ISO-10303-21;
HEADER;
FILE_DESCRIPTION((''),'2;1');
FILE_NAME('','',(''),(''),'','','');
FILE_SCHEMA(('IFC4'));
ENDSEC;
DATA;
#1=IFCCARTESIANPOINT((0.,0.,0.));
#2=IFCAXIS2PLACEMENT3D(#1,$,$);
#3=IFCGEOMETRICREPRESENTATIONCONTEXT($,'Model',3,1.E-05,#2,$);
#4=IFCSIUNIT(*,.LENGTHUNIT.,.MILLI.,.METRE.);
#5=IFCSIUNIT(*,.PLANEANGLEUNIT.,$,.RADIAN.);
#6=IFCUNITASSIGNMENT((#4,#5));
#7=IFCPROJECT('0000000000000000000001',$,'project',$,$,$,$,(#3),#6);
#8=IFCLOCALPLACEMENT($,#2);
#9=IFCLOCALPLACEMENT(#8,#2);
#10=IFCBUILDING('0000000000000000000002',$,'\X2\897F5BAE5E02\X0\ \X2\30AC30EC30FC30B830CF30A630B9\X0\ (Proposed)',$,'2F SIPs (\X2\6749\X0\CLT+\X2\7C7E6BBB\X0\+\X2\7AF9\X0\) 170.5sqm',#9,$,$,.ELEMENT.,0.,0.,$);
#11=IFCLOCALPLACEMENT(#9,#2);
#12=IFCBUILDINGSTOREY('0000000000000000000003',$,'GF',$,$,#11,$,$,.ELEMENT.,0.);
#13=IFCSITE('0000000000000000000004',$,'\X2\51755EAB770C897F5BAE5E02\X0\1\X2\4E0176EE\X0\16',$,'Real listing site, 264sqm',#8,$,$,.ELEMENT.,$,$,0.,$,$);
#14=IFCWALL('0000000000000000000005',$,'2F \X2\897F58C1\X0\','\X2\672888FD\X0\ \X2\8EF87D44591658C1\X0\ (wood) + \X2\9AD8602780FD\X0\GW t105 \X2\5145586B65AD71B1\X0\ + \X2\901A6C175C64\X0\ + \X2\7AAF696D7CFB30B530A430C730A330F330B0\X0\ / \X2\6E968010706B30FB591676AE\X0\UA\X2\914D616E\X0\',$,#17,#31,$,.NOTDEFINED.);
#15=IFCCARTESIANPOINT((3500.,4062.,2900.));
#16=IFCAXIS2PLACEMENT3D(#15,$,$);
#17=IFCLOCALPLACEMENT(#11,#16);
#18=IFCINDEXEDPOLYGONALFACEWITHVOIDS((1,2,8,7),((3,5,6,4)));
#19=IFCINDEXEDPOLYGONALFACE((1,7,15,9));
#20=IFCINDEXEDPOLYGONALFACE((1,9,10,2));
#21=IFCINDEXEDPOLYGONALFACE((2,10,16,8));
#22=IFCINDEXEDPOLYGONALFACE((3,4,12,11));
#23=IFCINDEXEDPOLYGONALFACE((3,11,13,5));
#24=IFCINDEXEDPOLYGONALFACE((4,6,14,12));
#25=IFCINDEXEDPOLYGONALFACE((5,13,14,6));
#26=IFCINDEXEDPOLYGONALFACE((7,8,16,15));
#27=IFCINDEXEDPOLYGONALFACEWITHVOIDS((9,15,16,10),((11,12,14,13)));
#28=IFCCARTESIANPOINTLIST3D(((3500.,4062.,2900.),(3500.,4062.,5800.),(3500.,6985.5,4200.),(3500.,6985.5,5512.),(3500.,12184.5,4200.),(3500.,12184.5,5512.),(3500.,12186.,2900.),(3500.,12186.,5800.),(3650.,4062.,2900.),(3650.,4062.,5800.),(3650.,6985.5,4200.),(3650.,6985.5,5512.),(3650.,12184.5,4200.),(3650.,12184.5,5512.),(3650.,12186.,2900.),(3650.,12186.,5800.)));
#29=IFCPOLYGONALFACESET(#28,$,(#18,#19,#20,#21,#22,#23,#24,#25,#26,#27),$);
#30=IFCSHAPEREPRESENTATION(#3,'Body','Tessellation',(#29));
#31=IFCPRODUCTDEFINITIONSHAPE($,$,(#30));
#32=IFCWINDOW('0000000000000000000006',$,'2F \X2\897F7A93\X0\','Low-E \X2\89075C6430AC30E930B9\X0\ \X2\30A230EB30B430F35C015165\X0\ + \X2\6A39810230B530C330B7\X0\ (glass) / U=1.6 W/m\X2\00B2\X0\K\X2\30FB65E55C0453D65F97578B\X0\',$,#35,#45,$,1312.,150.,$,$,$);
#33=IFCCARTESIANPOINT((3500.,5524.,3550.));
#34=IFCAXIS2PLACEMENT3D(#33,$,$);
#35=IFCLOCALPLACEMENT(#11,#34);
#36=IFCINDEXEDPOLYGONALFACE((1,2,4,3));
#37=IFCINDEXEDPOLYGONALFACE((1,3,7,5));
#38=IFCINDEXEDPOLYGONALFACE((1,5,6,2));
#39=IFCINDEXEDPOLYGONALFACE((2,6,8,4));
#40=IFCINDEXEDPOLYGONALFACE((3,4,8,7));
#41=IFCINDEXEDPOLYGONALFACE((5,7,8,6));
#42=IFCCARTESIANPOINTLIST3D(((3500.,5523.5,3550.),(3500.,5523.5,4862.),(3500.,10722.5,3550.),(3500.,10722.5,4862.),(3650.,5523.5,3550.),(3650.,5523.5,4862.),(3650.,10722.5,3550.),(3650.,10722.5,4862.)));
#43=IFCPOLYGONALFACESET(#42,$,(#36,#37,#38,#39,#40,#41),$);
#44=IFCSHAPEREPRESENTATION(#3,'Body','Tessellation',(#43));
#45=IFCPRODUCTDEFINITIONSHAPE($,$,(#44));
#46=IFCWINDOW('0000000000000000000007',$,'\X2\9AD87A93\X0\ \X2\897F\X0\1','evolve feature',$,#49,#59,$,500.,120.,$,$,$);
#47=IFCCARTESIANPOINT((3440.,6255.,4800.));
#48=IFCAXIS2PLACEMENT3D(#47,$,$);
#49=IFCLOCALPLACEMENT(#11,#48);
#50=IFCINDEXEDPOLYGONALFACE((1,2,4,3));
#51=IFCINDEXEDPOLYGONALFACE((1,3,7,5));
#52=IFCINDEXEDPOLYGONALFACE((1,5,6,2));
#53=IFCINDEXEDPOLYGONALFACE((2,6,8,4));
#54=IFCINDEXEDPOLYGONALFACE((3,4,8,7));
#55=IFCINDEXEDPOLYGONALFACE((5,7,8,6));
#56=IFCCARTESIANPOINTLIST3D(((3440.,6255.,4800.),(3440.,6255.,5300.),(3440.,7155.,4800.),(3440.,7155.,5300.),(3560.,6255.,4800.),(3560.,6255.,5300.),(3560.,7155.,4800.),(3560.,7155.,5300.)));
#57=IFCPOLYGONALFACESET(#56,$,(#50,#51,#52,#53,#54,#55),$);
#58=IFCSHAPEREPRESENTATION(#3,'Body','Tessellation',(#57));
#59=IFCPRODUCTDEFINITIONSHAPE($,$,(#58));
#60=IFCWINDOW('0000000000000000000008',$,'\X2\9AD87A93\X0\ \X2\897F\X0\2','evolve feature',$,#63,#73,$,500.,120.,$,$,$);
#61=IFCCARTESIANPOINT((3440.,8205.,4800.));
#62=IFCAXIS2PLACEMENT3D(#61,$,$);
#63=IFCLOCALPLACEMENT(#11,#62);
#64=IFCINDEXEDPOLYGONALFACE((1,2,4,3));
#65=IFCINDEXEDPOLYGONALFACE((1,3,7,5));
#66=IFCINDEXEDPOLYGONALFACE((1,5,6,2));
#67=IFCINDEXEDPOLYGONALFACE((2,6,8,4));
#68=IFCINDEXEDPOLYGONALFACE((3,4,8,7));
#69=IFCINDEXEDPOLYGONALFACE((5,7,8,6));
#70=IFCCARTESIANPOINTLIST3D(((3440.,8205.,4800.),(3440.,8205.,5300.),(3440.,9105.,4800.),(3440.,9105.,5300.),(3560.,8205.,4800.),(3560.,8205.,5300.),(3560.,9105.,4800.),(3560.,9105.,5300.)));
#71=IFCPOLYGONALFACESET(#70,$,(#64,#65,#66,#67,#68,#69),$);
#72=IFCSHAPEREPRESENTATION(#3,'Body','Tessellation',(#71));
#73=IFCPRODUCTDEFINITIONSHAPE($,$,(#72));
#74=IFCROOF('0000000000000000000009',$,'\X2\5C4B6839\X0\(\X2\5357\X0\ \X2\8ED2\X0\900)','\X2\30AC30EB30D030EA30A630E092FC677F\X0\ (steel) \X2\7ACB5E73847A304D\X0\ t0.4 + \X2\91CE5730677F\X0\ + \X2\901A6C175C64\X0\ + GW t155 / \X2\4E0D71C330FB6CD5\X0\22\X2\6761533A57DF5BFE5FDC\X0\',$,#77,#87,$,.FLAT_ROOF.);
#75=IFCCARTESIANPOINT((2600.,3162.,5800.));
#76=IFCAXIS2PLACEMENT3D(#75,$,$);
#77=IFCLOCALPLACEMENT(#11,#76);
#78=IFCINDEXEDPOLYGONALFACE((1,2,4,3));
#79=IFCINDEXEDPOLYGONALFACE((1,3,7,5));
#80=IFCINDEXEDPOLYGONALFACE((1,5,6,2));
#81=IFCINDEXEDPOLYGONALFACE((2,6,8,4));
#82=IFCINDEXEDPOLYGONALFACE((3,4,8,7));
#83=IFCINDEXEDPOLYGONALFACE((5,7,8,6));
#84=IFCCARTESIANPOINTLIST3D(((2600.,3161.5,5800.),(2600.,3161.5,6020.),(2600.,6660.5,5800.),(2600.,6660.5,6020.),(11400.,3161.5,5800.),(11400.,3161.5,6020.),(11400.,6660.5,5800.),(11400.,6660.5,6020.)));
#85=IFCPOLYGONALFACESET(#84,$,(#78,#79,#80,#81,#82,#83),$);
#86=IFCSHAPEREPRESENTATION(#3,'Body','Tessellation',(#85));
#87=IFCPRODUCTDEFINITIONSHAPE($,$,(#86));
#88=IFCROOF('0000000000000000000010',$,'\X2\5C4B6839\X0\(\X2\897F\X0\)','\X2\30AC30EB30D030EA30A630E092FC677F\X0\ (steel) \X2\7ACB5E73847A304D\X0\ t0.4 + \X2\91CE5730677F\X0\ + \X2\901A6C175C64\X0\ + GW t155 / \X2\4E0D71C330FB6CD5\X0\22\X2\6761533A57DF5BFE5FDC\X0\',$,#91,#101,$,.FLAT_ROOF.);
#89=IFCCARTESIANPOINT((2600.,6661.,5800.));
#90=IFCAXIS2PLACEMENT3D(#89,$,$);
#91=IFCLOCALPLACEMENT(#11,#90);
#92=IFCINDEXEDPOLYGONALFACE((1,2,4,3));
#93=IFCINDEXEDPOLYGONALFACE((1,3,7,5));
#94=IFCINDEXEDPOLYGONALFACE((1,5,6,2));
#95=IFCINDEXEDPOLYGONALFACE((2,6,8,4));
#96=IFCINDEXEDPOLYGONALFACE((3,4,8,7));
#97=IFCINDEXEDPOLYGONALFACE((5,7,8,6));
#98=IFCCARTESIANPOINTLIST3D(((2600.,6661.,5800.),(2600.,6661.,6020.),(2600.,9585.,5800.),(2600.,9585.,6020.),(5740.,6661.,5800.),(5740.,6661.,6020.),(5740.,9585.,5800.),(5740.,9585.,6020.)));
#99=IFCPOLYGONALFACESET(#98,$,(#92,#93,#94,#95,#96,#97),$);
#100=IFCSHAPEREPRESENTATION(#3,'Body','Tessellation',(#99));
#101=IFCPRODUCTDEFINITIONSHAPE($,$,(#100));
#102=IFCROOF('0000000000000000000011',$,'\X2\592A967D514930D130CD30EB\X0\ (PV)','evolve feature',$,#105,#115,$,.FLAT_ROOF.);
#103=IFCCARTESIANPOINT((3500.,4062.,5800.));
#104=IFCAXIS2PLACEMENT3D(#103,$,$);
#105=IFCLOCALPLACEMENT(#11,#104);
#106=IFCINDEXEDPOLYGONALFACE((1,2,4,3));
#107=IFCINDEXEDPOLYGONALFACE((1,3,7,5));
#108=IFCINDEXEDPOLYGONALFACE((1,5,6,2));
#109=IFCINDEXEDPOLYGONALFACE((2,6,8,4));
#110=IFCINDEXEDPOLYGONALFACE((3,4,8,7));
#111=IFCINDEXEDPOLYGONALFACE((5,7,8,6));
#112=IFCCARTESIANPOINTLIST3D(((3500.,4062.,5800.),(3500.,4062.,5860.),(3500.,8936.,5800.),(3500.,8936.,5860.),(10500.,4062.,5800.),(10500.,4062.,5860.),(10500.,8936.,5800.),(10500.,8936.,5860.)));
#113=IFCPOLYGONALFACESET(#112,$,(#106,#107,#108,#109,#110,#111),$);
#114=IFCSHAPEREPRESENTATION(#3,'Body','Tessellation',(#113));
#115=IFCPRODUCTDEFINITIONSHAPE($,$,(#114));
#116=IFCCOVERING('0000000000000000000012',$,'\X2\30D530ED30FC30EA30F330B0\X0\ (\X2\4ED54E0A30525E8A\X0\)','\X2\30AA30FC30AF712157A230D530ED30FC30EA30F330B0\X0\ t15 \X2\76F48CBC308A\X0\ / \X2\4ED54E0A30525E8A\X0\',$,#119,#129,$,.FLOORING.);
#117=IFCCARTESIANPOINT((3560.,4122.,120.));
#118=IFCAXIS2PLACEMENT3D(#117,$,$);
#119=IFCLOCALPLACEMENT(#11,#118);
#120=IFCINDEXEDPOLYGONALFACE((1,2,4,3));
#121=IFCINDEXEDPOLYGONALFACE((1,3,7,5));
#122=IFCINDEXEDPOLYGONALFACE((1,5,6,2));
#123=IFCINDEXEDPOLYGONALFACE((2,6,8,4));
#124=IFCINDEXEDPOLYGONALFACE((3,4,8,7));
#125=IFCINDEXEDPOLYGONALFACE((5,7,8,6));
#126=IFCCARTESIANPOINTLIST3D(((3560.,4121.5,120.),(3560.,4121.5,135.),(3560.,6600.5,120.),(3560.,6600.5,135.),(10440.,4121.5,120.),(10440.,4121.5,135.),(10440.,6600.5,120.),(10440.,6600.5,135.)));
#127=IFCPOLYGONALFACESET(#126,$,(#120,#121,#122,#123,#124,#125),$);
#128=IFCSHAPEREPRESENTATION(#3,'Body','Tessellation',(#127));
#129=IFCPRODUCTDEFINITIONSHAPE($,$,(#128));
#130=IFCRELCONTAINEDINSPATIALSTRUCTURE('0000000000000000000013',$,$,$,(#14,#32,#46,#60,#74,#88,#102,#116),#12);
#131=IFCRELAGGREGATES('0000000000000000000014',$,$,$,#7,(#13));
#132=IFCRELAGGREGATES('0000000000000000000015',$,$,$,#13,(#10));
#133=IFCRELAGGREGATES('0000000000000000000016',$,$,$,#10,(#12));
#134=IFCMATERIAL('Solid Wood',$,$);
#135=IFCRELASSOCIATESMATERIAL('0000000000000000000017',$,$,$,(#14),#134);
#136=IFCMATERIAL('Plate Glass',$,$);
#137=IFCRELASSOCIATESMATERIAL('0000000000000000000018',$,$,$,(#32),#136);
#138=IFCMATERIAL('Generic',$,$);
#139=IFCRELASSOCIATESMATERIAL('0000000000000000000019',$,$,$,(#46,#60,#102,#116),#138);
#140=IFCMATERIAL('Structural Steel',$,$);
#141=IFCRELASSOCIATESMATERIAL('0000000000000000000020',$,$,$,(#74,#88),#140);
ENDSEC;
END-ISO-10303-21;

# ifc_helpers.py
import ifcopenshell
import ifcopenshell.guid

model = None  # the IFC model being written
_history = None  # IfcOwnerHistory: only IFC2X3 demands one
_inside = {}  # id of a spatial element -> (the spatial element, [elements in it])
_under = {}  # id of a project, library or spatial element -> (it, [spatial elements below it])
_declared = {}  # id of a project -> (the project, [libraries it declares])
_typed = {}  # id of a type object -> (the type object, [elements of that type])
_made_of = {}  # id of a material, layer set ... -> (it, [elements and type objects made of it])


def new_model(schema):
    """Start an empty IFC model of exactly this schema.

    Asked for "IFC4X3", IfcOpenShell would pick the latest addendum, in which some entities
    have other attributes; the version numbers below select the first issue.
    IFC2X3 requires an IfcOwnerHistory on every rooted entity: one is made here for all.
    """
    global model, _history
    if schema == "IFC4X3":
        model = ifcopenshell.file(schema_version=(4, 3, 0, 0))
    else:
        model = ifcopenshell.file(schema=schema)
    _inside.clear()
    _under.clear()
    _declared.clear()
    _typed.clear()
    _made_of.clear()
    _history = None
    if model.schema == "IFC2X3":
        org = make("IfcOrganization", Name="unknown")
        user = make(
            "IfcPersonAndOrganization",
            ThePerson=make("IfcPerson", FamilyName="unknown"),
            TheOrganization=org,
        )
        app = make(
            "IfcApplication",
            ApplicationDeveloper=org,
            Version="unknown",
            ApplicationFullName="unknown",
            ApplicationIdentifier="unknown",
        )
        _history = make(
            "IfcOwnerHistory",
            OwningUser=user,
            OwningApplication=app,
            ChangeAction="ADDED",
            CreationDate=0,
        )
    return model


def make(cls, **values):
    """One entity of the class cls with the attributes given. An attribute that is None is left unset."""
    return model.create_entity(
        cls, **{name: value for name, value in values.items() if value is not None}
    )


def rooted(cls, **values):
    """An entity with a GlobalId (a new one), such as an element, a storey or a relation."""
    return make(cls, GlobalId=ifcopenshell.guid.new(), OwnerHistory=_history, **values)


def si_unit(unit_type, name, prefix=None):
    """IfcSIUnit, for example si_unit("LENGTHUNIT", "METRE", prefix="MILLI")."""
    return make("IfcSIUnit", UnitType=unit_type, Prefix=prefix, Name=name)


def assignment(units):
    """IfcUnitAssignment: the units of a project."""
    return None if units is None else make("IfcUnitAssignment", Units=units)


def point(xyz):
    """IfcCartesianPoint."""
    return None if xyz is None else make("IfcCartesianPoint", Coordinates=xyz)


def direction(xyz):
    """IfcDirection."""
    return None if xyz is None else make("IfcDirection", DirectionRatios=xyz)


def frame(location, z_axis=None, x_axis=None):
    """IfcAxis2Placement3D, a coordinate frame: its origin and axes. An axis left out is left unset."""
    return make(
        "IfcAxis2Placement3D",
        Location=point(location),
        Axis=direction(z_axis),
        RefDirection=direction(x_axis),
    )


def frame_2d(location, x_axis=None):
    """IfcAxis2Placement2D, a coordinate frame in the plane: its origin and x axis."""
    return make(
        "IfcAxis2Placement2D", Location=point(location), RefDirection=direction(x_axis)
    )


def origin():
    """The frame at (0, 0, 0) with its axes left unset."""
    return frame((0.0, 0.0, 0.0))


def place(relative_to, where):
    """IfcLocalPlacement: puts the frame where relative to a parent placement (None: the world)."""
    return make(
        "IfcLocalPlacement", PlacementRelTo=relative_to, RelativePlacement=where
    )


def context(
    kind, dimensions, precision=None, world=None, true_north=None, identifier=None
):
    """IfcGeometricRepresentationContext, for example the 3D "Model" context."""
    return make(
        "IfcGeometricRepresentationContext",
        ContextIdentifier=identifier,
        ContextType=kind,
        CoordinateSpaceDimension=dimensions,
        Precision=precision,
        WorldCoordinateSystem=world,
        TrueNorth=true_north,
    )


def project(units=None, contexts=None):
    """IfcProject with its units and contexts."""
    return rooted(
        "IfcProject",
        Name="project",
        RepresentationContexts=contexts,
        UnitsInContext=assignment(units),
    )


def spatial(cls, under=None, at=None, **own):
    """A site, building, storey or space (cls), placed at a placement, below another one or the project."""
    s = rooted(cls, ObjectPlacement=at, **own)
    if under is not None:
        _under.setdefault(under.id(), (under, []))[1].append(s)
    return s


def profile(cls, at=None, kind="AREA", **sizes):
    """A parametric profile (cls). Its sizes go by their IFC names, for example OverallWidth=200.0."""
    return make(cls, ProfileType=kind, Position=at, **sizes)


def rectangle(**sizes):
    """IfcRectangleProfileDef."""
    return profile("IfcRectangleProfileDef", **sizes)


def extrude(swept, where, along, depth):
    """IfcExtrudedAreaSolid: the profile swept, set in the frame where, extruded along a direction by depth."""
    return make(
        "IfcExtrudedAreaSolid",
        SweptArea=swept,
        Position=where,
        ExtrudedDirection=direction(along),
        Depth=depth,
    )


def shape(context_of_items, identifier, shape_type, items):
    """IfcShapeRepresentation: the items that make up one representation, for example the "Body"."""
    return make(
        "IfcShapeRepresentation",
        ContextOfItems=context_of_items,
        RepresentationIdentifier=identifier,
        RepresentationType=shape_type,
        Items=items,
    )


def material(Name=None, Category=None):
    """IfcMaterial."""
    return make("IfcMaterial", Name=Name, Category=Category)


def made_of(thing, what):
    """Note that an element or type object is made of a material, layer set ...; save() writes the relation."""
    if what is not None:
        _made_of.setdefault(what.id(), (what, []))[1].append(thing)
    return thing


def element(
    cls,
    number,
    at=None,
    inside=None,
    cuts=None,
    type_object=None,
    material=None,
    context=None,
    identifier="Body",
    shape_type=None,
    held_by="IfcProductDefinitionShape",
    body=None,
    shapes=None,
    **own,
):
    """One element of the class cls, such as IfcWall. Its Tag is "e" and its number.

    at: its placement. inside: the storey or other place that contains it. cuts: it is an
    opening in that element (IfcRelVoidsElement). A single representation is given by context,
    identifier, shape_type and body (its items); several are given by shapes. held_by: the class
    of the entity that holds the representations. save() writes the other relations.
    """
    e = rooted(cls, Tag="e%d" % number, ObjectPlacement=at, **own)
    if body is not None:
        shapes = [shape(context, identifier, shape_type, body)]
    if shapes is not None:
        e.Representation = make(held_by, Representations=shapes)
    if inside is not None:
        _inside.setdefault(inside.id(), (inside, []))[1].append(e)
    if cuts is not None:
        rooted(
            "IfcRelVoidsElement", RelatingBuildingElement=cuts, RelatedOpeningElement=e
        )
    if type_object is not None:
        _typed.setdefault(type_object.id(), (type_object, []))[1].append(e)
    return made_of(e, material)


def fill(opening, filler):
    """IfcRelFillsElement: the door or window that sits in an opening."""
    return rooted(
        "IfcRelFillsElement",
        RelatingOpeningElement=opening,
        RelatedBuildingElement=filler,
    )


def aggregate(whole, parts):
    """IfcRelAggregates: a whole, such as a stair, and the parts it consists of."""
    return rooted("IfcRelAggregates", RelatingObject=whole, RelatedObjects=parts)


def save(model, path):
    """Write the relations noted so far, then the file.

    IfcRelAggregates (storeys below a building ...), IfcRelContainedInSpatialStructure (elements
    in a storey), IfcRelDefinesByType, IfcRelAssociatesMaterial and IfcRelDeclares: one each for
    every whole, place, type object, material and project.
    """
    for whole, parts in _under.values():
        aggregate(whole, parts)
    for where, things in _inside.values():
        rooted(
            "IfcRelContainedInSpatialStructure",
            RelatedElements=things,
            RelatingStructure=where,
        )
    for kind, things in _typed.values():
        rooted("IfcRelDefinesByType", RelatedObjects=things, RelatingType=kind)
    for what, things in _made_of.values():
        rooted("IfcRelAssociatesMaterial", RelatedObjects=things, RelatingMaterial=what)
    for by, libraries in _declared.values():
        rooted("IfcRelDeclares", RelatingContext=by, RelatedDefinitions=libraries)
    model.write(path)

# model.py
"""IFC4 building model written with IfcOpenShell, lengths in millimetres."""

from ifc_helpers import new_model, si_unit, frame, frame_2d, origin, place, context, project, spatial, rectangle, extrude, material, element, fill, save


model = new_model("IFC4")

# Units and contexts
model_context = context("Model", 3, precision=1e-05, world=origin())
ifc_project = project(units=[si_unit("LENGTHUNIT", "METRE", prefix="MILLI"), si_unit("PLANEANGLEUNIT", "RADIAN")], contexts=[model_context])

# Site, building, storey
site_placement = place(None, origin())
site = spatial("IfcSite", under=ifc_project, at=site_placement, Name="兵庫県西宮市1丁目16", ObjectType="Real listing site, 264sqm", CompositionType="ELEMENT", RefElevation=0.0)
building_placement = place(site_placement, origin())
building = spatial("IfcBuilding", under=site, at=building_placement, Name="西宮市 ガレージハウス (Proposed)", ObjectType="2F SIPs (杉CLT+籾殻+竹) 170.5sqm", CompositionType="ELEMENT", ElevationOfRefHeight=0.0, ElevationOfTerrain=0.0)
storey_placement = place(building_placement, origin())
storey = spatial("IfcBuildingStorey", under=building, at=storey_placement, Name="GF", CompositionType="ELEMENT", Elevation=0.0)

# Shared definitions
ifc_material_1 = material(Name="Solid Wood")
ifc_material_2 = material(Name="Generic")

# Shared definitions
ifc_material_3 = material(Name="Plate Glass")

# Wall, openings, windows
wall_1_placement = place(storey_placement, frame((3500.0, 4062.0, 2900.0)))
wall_1 = element("IfcWall", 1, at=wall_1_placement, inside=storey, material=ifc_material_1, Name="2F 西壁", Description="木製 軸組外壁 (wood) + 高性能GW t105 充填断熱 + 通気層 + 窯業系サイディング / 準耐火・外皮UA配慮", PredefinedType="NOTDEFINED", context=model_context, shape_type="SweptSolid", body=[
    extrude(rectangle(XDim=150.0, YDim=8124.0, at=frame_2d((75.0, 4062.0))), frame((3500.0, 4062.0, 2900.0)), (0.0, 0.0, 1.0), 2900.0),
])
opening_1_placement = place(storey_placement, frame((3500.0, 5524.0, 3550.0)))
opening_1 = element("IfcOpeningElement", 2, at=opening_1_placement, cuts=wall_1, PredefinedType="NOTDEFINED", context=model_context, shape_type="SweptSolid", body=[
    extrude(rectangle(XDim=150.0, YDim=5199.0, at=frame_2d((75.0, 2599.0))), frame((3500.0, 5524.0, 3550.0)), (0.0, 0.0, 1.0), 1312.0),
])
opening_2_placement = place(storey_placement, frame((3440.0, 6255.0, 4800.0)))
opening_2 = element("IfcOpeningElement", 3, at=opening_2_placement, cuts=wall_1, PredefinedType="NOTDEFINED", context=model_context, shape_type="SweptSolid", body=[
    extrude(rectangle(XDim=120.0, YDim=900.0, at=frame_2d((60.0, 450.0))), frame((3440.0, 6255.0, 4800.0)), (0.0, 0.0, 1.0), 500.0),
])
opening_3_placement = place(storey_placement, frame((3440.0, 8205.0, 4800.0)))
opening_3 = element("IfcOpeningElement", 4, at=opening_3_placement, cuts=wall_1, PredefinedType="NOTDEFINED", context=model_context, shape_type="SweptSolid", body=[
    extrude(rectangle(XDim=120.0, YDim=900.0, at=frame_2d((60.0, 450.0))), frame((3440.0, 8205.0, 4800.0)), (0.0, 0.0, 1.0), 500.0),
])
window_1_placement = place(storey_placement, frame((3500.0, 5524.0, 3550.0)))
window_1 = element("IfcWindow", 5, at=window_1_placement, inside=storey, material=ifc_material_3, Name="2F 西窓", Description="Low-E 複層ガラス アルゴン封入 + 樹脂サッシ (glass) / U=1.6 W/m²K・日射取得型", OverallHeight=1312.0, OverallWidth=150.0, context=model_context, shape_type="SweptSolid", body=[
    extrude(rectangle(XDim=150.0, YDim=5199.0, at=frame_2d((75.0, 2599.0))), frame((3500.0, 5524.0, 3550.0)), (0.0, 0.0, 1.0), 1312.0),
])
fill(opening_1, window_1)
window_2_placement = place(storey_placement, frame((3440.0, 6255.0, 4800.0)))
window_2 = element("IfcWindow", 6, at=window_2_placement, inside=storey, material=ifc_material_2, Name="高窓 西1", Description="evolve feature", OverallHeight=500.0, OverallWidth=120.0, context=model_context, shape_type="SweptSolid", body=[
    extrude(rectangle(XDim=120.0, YDim=900.0, at=frame_2d((60.0, 450.0))), frame((3440.0, 6255.0, 4800.0)), (0.0, 0.0, 1.0), 500.0),
])
fill(opening_2, window_2)
window_3_placement = place(storey_placement, frame((3440.0, 8205.0, 4800.0)))
window_3 = element("IfcWindow", 7, at=window_3_placement, inside=storey, material=ifc_material_2, Name="高窓 西2", Description="evolve feature", OverallHeight=500.0, OverallWidth=120.0, context=model_context, shape_type="SweptSolid", body=[
    extrude(rectangle(XDim=120.0, YDim=900.0, at=frame_2d((60.0, 450.0))), frame((3440.0, 8205.0, 4800.0)), (0.0, 0.0, 1.0), 500.0),
])
fill(opening_3, window_3)

# Roofs
ifc_material_4 = material(Name="Structural Steel")
roof_1_placement = place(storey_placement, frame((2600.0, 3162.0, 5800.0)))
element("IfcRoof", 8, at=roof_1_placement, inside=storey, material=ifc_material_4, Name="屋根(南 軒900)", Description="ガルバリウム鋼板 (steel) 立平葺き t0.4 + 野地板 + 通気層 + GW t155 / 不燃・法22条区域対応", PredefinedType="FLAT_ROOF", context=model_context, shape_type="SweptSolid", body=[
    extrude(rectangle(XDim=8800.0, YDim=3499.0, at=frame_2d((4400.0, 1749.0))), frame((2600.0, 3162.0, 5800.0)), (0.0, 0.0, 1.0), 220.0),
])
roof_2_placement = place(storey_placement, frame((2600.0, 6661.0, 5800.0)))
element("IfcRoof", 9, at=roof_2_placement, inside=storey, material=ifc_material_4, Name="屋根(西)", Description="ガルバリウム鋼板 (steel) 立平葺き t0.4 + 野地板 + 通気層 + GW t155 / 不燃・法22条区域対応", PredefinedType="FLAT_ROOF", context=model_context, shape_type="SweptSolid", body=[
    extrude(rectangle(XDim=3140.0, YDim=2924.0, at=frame_2d((1570.0, 1462.0))), frame((2600.0, 6661.0, 5800.0)), (0.0, 0.0, 1.0), 220.0),
])
roof_3_placement = place(storey_placement, frame((3500.0, 4062.0, 5800.0)))
element("IfcRoof", 10, at=roof_3_placement, inside=storey, material=ifc_material_2, Name="太陽光パネル (PV)", Description="evolve feature", PredefinedType="FLAT_ROOF", context=model_context, shape_type="SweptSolid", body=[
    extrude(rectangle(XDim=7000.0, YDim=4874.0, at=frame_2d((3500.0, 2437.0))), frame((3500.0, 4062.0, 5800.0)), (0.0, 0.0, 1.0), 60.0),
])

# Covering
covering_placement = place(storey_placement, frame((3560.0, 4122.0, 120.0)))
element("IfcCovering", 11, at=covering_placement, inside=storey, material=ifc_material_2, Name="フローリング (仕上げ床)", Description="オーク無垢フローリング t15 直貼り / 仕上げ床", PredefinedType="FLOORING", context=model_context, shape_type="SweptSolid", body=[
    extrude(rectangle(XDim=6880.0, YDim=2479.0, at=frame_2d((3440.0, 1239.0))), frame((3560.0, 4122.0, 120.0)), (0.0, 0.0, 1.0), 15.0),
])

save(model, "model.ifc")
